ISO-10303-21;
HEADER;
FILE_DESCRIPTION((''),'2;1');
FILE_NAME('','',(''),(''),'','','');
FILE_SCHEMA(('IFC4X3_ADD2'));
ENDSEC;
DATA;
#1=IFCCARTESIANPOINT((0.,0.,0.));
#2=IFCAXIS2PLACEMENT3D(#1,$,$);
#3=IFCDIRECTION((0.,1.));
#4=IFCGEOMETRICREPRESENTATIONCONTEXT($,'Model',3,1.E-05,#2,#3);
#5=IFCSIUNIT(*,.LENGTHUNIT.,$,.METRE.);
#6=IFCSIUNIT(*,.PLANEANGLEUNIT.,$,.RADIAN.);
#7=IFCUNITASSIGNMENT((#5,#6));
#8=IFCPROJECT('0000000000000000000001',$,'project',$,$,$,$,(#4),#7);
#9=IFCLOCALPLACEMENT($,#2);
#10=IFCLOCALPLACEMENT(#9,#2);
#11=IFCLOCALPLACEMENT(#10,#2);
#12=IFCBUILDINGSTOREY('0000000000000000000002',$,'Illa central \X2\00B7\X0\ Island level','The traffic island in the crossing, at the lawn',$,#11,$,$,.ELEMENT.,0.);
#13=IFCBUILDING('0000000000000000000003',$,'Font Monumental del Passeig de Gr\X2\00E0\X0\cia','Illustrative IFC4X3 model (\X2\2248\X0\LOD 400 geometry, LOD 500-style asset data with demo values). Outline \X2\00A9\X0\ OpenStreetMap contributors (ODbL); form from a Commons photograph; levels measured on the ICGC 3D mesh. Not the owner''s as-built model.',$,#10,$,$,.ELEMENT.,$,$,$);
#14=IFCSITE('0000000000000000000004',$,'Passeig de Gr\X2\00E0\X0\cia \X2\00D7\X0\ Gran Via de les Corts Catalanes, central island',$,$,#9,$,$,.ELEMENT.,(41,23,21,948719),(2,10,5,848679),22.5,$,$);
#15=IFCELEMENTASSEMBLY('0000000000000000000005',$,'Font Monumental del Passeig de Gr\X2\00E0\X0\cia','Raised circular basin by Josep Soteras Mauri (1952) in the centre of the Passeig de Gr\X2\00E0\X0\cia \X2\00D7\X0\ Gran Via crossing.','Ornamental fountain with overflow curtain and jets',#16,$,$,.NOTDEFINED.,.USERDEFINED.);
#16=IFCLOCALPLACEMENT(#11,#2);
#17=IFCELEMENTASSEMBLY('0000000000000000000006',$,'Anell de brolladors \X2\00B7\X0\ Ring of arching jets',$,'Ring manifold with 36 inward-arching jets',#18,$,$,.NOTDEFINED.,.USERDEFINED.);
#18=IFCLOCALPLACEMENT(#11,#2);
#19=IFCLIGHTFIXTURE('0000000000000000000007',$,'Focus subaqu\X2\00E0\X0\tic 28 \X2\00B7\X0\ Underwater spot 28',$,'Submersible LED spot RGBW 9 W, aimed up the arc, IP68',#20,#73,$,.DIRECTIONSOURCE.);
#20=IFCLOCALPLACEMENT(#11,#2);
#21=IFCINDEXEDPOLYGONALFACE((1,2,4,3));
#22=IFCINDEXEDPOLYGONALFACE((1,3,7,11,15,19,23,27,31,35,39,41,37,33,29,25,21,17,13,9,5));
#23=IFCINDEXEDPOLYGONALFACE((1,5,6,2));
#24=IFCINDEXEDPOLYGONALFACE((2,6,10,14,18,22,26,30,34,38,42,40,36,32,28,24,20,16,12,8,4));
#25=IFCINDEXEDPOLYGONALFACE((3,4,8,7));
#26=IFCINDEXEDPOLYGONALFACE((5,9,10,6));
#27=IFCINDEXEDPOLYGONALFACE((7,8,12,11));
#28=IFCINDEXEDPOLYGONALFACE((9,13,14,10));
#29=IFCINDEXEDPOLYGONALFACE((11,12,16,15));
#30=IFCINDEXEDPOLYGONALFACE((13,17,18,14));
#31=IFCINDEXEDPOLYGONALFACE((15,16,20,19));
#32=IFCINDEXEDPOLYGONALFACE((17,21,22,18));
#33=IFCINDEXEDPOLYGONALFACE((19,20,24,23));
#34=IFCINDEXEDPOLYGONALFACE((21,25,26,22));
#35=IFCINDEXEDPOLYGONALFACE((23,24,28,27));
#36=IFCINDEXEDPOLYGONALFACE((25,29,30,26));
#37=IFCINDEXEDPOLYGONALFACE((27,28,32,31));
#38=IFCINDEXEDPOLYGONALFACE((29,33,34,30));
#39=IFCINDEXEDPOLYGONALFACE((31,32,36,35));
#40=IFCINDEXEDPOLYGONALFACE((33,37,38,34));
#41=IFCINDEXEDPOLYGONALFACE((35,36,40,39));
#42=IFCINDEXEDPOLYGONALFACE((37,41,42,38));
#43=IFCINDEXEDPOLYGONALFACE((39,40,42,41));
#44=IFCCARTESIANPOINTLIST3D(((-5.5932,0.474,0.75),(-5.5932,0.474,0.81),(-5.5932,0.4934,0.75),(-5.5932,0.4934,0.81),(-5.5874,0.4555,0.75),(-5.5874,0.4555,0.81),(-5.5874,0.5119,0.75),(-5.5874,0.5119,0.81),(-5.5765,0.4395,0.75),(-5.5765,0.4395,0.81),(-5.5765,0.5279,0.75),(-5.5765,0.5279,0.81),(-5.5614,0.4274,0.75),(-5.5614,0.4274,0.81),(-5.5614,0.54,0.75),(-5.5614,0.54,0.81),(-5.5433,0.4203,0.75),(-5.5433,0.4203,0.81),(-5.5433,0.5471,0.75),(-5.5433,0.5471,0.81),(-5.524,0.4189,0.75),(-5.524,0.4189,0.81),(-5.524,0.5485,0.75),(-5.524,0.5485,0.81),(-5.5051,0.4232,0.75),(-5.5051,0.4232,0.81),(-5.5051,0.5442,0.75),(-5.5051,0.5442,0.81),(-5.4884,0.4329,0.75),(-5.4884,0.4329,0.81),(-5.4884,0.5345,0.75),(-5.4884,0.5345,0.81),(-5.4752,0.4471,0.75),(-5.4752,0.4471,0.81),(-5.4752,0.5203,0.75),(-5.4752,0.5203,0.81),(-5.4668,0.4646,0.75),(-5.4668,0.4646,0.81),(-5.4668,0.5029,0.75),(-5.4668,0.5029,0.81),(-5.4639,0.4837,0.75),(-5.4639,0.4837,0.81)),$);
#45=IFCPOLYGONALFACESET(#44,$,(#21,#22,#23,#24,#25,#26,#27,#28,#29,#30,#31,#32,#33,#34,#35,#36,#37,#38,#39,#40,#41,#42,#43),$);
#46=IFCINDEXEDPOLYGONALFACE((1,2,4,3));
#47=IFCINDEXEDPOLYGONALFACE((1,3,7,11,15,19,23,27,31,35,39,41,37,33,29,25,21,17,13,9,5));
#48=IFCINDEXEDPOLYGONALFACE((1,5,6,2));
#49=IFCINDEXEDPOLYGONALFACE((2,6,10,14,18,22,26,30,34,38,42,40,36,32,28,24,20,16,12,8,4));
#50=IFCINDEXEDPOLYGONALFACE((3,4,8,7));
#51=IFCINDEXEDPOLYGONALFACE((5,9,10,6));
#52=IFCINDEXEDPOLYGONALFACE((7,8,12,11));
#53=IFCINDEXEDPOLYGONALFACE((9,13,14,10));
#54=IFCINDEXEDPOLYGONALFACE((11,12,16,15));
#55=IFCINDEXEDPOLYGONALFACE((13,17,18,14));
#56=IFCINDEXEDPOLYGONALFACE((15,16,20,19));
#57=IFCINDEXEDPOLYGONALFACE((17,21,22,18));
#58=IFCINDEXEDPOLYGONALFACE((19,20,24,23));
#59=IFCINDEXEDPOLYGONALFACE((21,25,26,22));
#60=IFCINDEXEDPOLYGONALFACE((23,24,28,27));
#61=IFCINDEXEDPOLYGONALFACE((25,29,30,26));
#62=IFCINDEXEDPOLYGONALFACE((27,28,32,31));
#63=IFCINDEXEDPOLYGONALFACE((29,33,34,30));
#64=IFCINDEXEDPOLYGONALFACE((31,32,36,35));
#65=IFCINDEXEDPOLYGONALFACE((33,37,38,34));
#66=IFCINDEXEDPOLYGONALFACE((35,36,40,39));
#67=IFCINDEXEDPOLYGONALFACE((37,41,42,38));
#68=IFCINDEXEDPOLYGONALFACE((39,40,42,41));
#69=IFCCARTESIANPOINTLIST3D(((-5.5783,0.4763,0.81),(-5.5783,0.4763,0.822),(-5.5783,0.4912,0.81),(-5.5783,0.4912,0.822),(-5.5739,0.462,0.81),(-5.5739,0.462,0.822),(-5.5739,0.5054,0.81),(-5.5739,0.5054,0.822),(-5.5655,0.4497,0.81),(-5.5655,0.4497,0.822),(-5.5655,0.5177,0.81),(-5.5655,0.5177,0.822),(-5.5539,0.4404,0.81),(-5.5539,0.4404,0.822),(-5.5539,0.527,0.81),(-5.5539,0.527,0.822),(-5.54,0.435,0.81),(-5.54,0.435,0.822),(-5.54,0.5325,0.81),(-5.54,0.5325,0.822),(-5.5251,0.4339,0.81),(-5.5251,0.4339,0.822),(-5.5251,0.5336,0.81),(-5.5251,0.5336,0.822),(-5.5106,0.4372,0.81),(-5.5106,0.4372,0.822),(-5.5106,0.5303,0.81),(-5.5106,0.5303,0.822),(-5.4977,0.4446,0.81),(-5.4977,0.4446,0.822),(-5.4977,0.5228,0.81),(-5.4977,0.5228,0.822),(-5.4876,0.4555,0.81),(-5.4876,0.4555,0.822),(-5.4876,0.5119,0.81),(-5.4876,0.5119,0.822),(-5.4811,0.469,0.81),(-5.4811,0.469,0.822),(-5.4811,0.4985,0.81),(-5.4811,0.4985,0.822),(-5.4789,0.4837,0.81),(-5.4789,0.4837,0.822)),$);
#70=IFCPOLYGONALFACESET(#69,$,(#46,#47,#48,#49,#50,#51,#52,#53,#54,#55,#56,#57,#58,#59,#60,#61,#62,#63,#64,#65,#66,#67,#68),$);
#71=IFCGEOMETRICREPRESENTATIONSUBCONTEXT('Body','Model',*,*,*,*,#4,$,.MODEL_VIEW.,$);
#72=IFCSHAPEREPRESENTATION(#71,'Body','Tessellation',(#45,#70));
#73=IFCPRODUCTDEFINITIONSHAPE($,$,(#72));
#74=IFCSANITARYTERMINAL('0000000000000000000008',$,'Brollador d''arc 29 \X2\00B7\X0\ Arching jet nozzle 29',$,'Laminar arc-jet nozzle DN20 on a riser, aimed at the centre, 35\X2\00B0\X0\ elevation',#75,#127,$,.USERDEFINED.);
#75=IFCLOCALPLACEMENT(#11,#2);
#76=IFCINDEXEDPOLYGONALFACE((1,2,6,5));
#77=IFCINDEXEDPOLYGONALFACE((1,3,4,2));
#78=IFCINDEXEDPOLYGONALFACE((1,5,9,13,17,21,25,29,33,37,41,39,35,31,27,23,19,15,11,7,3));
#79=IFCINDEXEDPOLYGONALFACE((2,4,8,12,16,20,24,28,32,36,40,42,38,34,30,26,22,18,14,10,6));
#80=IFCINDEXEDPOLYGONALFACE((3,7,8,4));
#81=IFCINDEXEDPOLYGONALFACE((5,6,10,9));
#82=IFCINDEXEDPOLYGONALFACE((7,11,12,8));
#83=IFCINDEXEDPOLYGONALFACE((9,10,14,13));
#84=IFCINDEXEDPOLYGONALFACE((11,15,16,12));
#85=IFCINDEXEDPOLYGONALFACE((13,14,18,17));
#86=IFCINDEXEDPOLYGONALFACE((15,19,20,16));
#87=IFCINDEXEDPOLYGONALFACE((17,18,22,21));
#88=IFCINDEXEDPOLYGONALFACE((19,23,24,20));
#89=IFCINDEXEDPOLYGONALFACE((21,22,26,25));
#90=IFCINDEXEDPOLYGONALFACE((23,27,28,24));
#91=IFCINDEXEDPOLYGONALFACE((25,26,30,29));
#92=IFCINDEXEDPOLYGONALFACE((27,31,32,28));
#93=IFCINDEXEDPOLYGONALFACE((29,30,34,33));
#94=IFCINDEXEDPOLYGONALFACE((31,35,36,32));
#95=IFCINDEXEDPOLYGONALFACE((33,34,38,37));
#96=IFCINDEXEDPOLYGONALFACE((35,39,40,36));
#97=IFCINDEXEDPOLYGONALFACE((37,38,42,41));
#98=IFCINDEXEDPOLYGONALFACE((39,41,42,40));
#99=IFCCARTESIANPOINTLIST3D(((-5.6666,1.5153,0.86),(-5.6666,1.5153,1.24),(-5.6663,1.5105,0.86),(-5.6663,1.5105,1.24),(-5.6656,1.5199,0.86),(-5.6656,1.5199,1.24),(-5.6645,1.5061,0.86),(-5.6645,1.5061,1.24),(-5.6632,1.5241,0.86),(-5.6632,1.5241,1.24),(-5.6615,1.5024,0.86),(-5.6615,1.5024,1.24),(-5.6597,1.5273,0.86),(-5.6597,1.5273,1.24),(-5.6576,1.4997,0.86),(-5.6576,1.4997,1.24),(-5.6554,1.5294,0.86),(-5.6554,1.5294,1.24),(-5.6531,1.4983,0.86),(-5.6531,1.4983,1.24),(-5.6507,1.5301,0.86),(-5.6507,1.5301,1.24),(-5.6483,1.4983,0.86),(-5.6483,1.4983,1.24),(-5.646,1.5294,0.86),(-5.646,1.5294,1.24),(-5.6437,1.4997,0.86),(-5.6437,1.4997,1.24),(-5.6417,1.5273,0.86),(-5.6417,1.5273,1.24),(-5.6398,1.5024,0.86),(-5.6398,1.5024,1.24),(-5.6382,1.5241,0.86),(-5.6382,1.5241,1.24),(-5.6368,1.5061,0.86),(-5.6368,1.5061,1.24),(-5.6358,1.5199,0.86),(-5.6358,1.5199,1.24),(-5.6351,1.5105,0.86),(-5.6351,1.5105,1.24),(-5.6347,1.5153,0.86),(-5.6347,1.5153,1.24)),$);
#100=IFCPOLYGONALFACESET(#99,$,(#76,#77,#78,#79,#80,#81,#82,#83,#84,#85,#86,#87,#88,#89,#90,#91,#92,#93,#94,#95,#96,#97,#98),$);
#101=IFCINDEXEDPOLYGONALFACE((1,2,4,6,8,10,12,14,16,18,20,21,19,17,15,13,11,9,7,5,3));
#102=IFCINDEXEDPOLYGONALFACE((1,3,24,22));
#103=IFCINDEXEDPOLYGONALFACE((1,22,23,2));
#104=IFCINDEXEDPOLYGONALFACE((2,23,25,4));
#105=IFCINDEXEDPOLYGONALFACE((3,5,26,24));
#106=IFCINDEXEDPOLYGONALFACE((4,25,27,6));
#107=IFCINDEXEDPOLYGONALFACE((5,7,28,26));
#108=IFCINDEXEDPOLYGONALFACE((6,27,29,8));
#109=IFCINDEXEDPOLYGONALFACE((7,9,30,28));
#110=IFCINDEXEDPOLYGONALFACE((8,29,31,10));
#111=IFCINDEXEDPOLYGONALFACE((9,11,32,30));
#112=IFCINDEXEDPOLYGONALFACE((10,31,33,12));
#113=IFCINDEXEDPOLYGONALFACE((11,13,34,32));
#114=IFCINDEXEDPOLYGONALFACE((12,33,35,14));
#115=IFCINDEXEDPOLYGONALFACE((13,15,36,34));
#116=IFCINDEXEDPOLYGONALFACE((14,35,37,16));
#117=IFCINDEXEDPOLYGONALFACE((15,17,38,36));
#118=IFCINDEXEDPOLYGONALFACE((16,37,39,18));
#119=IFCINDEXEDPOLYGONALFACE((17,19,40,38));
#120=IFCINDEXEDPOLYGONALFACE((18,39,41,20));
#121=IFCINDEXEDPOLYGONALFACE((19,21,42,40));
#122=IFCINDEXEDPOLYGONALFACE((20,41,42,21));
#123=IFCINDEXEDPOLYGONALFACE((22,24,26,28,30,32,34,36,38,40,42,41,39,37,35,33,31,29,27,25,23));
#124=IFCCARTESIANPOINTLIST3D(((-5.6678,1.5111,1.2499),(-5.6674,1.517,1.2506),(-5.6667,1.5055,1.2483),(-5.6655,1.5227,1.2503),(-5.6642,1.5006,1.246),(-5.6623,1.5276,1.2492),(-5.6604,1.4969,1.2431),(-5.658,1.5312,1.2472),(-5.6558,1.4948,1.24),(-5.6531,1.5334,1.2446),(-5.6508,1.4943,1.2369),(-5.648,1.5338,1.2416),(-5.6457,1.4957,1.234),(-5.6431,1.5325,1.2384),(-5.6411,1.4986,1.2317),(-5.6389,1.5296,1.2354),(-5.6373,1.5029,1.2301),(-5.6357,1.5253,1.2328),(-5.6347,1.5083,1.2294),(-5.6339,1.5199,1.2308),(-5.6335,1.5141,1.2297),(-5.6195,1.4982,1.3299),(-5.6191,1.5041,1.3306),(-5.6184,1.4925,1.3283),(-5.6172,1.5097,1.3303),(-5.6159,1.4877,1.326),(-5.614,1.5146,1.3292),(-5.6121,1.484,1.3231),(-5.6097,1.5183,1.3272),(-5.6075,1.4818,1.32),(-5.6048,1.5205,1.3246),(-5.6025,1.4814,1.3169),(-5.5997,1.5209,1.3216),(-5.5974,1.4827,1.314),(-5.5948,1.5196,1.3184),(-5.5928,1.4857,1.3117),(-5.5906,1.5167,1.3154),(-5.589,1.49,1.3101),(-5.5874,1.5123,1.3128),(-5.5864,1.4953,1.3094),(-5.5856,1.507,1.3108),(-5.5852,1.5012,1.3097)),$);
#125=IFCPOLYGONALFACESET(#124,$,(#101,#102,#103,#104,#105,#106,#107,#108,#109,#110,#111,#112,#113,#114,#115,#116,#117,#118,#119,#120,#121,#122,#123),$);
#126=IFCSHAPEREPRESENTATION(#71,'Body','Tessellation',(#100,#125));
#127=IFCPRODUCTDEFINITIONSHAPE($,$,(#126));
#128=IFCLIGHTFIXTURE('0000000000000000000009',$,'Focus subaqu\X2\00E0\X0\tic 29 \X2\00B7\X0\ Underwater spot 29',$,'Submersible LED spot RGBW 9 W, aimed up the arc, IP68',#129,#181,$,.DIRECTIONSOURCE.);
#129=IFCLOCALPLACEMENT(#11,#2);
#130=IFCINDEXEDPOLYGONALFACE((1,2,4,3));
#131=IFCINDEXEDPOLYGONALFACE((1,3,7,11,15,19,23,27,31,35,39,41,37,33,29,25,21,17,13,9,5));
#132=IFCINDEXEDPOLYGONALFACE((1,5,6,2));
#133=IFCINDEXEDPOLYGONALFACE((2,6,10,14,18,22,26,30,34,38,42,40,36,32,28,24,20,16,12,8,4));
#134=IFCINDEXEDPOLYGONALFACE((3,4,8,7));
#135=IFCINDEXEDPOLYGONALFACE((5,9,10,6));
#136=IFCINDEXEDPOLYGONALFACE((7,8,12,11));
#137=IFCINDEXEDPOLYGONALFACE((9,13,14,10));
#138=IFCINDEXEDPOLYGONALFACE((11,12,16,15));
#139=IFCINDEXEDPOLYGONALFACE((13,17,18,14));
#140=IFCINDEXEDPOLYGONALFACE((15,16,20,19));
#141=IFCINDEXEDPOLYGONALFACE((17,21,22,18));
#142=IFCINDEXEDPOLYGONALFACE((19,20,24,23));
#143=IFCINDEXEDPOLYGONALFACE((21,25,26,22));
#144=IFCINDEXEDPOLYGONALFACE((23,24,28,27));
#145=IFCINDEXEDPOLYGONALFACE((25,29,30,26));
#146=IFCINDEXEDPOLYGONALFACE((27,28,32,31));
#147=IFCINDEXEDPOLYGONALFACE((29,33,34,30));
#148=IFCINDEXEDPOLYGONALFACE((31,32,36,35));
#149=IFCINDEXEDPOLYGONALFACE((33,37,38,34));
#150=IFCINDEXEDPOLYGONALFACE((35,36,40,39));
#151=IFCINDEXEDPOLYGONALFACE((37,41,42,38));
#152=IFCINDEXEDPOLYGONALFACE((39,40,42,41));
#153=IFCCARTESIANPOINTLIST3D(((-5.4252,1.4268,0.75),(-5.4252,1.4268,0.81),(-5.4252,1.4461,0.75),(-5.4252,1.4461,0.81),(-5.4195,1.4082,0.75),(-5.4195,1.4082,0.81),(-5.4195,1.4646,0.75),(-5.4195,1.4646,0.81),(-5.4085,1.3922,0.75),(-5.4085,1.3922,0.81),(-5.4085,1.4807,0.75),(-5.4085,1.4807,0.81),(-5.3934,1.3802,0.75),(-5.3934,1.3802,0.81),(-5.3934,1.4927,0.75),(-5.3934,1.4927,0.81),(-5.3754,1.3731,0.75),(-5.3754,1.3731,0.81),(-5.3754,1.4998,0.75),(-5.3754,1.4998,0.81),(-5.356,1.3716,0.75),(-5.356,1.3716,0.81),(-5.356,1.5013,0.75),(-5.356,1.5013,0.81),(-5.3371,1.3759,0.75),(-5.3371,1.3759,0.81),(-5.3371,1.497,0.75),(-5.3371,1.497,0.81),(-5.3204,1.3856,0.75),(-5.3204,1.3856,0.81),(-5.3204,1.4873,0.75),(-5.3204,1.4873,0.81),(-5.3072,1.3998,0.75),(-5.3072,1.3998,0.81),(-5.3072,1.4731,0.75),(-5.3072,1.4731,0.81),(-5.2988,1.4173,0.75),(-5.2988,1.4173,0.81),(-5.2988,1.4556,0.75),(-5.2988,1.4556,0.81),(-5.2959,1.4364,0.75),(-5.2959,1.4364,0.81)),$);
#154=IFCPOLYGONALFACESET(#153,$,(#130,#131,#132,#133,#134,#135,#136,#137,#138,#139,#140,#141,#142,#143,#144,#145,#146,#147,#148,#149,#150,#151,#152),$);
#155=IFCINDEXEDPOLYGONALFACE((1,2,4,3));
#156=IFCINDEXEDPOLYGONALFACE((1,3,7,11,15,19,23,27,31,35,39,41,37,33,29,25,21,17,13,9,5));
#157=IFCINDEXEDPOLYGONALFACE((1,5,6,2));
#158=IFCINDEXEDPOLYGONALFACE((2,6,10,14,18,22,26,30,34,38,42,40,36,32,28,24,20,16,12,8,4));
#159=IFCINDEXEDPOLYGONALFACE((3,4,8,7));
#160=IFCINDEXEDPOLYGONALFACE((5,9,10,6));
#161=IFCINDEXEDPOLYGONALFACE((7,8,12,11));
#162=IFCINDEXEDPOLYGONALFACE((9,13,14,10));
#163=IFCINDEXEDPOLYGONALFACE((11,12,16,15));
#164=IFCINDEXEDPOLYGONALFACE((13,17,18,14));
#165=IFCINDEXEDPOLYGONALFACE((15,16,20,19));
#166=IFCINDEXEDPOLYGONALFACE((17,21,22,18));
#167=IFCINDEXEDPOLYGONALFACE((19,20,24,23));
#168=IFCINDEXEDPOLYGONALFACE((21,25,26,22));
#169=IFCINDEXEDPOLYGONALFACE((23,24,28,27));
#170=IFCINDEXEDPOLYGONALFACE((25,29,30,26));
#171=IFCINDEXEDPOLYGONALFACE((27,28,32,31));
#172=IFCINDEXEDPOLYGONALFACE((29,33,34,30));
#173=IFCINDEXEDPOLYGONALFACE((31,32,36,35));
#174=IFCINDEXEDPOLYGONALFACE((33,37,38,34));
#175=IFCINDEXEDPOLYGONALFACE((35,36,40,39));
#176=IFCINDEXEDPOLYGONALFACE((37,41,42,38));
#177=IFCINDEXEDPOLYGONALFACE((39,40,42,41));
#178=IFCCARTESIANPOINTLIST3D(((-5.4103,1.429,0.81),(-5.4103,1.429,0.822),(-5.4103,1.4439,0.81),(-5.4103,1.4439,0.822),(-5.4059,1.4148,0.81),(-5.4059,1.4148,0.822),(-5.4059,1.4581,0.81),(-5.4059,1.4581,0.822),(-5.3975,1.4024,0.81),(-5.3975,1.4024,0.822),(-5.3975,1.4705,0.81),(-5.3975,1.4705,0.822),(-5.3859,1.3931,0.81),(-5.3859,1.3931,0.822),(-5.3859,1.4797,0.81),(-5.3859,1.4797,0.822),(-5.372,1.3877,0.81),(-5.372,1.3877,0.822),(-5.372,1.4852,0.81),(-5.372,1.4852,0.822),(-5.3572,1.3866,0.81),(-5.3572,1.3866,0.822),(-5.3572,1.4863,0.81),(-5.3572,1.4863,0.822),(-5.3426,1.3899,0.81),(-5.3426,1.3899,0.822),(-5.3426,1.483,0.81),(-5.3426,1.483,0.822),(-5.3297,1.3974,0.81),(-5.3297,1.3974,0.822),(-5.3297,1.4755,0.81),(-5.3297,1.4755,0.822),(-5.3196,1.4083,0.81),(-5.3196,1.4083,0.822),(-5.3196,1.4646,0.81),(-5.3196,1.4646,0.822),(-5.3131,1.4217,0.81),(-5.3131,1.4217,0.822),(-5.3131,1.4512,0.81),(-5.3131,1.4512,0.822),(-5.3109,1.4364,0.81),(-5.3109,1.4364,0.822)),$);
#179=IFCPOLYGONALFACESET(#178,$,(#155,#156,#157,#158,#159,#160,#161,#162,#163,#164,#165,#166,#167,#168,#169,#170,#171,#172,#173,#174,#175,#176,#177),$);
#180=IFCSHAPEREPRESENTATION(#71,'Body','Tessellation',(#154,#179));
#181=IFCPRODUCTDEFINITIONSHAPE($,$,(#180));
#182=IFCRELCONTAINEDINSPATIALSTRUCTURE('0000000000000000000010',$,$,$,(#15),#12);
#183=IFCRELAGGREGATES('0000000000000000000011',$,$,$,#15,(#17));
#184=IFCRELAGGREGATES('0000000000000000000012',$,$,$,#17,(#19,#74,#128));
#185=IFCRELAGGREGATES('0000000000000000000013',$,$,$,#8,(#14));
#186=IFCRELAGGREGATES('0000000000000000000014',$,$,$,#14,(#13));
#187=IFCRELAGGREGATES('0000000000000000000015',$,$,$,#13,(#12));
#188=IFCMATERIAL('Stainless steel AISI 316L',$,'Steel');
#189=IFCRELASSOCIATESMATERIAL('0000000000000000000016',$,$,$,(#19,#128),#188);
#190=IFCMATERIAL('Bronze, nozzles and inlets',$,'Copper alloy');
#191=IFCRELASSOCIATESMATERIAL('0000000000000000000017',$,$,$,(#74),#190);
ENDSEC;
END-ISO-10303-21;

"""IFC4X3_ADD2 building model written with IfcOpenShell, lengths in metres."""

from ifc_helpers import new_model, si_unit, direction, frame, origin, origin_2d_with_axis, place, context, subcontext, project, spatial, circle, extrude, material, element, aggregate, save


model = new_model("IFC4X3_ADD2")

# Units and contexts
model_context = context("Model", 3, precision=1e-05, world=origin(), true_north=direction((0.0, 1.0)))
body_context = subcontext(model_context, "Body", "Model", "MODEL_VIEW")
ifc_project = project(units=[si_unit("LENGTHUNIT", "METRE"), si_unit("PLANEANGLEUNIT", "RADIAN")], contexts=[model_context])

# Site, building, storey
site_placement = place(None, origin())
site = spatial("IfcSite", under=ifc_project, at=site_placement, Name="Passeig de Gràcia × Gran Via de les Corts Catalanes, central island", CompositionType="ELEMENT", RefLatitude=(41, 23, 21, 948719), RefLongitude=(2, 10, 5, 848679), RefElevation=22.5)
building_placement = place(site_placement, origin())
building = spatial("IfcBuilding", under=site, at=building_placement, Name="Font Monumental del Passeig de Gràcia", Description="Illustrative IFC4X3 model (≈LOD 400 geometry, LOD 500-style asset data with demo values). Outline © OpenStreetMap contributors (ODbL); form from a Commons photograph; levels measured on the ICGC 3D mesh. Not the owner's as-built model.", CompositionType="ELEMENT")
storey_placement = place(building_placement, origin())
storey = spatial("IfcBuildingStorey", under=building, at=storey_placement, Name="Illa central · Island level", Description="The traffic island in the crossing, at the lawn", CompositionType="ELEMENT", Elevation=0.0)

# Element assemblies, light fixtures, sanitary terminal
assembly_1_placement = place(building_placement, origin())
assembly_1 = element("IfcElementAssembly", 1, at=assembly_1_placement, inside=storey, Name="Font Monumental del Passeig de Gràcia", Description="Raised circular basin by Josep Soteras Mauri (1952) in the centre of the Passeig de Gràcia × Gran Via crossing.", ObjectType="Ornamental fountain with overflow curtain and jets", AssemblyPlace="NOTDEFINED", PredefinedType="USERDEFINED")
assembly_2_placement = place(building_placement, origin())
assembly_2 = element("IfcElementAssembly", 2, at=assembly_2_placement, Name="Anell de brolladors · Ring of arching jets", ObjectType="Ring manifold with 36 inward-arching jets", AssemblyPlace="NOTDEFINED", PredefinedType="USERDEFINED")
aggregate(assembly_1, [assembly_2])
ifc_material_1 = material(Name="Stainless steel AISI 316L", Category="Steel")
ifc_material_2 = material(Name="Bronze, nozzles and inlets", Category="Copper alloy")
light_fixture_1_placement = place(building_placement, origin())
light_fixture_1 = element("IfcLightFixture", 3, at=light_fixture_1_placement, material=ifc_material_1, Name="Focus subaquàtic 28 · Underwater spot 28", ObjectType="Submersible LED spot RGBW 9 W, aimed up the arc, IP68", PredefinedType="DIRECTIONSOURCE", context=body_context, shape_type="SweptSolid", body=[
    extrude(circle(Radius=0.065, at=origin_2d_with_axis()), frame((-5.5289, 0.4837, 0.75)), (0.0, 0.0, 1.0), 0.06),
    extrude(circle(Radius=0.05, at=origin_2d_with_axis()), frame((-5.5289, 0.4837, 0.81)), (0.0, 0.0, 1.0), 0.012),
])
sanitary_terminal_1_placement = place(building_placement, origin())
sanitary_terminal_1 = element("IfcSanitaryTerminal", 4, at=sanitary_terminal_1_placement, material=ifc_material_2, Name="Brollador d'arc 29 · Arching jet nozzle 29", ObjectType="Laminar arc-jet nozzle DN20 on a riser, aimed at the centre, 35° elevation", PredefinedType="USERDEFINED", context=body_context, shape_type="SweptSolid", body=[
    extrude(circle(Radius=0.016, at=origin_2d_with_axis()), frame((-5.6507, 1.5141, 0.86), z_axis=(0.0, 0.0, 1.0), x_axis=(0.0, 1.0, 0.0)), (0.0, 0.0, 1.0), 0.38),
    extrude(circle(Radius=0.02, at=origin_2d_with_axis()), frame((-5.6507, 1.5141, 1.24), z_axis=(0.51194, -0.137174, 0.847998), x_axis=(-0.258819, -0.965926, 0.0)), (0.0, 0.0, 1.0), 0.0943),
])
light_fixture_2_placement = place(building_placement, origin())
light_fixture_2 = element("IfcLightFixture", 5, at=light_fixture_2_placement, material=ifc_material_1, Name="Focus subaquàtic 29 · Underwater spot 29", ObjectType="Submersible LED spot RGBW 9 W, aimed up the arc, IP68", PredefinedType="DIRECTIONSOURCE", context=body_context, shape_type="SweptSolid", body=[
    extrude(circle(Radius=0.065, at=origin_2d_with_axis()), frame((-5.3609, 1.4364, 0.75)), (0.0, 0.0, 1.0), 0.06),
    extrude(circle(Radius=0.05, at=origin_2d_with_axis()), frame((-5.3609, 1.4364, 0.81)), (0.0, 0.0, 1.0), 0.012),
])
aggregate(assembly_2, [light_fixture_1, sanitary_terminal_1, light_fixture_2])

save(model, "model.ifc")
